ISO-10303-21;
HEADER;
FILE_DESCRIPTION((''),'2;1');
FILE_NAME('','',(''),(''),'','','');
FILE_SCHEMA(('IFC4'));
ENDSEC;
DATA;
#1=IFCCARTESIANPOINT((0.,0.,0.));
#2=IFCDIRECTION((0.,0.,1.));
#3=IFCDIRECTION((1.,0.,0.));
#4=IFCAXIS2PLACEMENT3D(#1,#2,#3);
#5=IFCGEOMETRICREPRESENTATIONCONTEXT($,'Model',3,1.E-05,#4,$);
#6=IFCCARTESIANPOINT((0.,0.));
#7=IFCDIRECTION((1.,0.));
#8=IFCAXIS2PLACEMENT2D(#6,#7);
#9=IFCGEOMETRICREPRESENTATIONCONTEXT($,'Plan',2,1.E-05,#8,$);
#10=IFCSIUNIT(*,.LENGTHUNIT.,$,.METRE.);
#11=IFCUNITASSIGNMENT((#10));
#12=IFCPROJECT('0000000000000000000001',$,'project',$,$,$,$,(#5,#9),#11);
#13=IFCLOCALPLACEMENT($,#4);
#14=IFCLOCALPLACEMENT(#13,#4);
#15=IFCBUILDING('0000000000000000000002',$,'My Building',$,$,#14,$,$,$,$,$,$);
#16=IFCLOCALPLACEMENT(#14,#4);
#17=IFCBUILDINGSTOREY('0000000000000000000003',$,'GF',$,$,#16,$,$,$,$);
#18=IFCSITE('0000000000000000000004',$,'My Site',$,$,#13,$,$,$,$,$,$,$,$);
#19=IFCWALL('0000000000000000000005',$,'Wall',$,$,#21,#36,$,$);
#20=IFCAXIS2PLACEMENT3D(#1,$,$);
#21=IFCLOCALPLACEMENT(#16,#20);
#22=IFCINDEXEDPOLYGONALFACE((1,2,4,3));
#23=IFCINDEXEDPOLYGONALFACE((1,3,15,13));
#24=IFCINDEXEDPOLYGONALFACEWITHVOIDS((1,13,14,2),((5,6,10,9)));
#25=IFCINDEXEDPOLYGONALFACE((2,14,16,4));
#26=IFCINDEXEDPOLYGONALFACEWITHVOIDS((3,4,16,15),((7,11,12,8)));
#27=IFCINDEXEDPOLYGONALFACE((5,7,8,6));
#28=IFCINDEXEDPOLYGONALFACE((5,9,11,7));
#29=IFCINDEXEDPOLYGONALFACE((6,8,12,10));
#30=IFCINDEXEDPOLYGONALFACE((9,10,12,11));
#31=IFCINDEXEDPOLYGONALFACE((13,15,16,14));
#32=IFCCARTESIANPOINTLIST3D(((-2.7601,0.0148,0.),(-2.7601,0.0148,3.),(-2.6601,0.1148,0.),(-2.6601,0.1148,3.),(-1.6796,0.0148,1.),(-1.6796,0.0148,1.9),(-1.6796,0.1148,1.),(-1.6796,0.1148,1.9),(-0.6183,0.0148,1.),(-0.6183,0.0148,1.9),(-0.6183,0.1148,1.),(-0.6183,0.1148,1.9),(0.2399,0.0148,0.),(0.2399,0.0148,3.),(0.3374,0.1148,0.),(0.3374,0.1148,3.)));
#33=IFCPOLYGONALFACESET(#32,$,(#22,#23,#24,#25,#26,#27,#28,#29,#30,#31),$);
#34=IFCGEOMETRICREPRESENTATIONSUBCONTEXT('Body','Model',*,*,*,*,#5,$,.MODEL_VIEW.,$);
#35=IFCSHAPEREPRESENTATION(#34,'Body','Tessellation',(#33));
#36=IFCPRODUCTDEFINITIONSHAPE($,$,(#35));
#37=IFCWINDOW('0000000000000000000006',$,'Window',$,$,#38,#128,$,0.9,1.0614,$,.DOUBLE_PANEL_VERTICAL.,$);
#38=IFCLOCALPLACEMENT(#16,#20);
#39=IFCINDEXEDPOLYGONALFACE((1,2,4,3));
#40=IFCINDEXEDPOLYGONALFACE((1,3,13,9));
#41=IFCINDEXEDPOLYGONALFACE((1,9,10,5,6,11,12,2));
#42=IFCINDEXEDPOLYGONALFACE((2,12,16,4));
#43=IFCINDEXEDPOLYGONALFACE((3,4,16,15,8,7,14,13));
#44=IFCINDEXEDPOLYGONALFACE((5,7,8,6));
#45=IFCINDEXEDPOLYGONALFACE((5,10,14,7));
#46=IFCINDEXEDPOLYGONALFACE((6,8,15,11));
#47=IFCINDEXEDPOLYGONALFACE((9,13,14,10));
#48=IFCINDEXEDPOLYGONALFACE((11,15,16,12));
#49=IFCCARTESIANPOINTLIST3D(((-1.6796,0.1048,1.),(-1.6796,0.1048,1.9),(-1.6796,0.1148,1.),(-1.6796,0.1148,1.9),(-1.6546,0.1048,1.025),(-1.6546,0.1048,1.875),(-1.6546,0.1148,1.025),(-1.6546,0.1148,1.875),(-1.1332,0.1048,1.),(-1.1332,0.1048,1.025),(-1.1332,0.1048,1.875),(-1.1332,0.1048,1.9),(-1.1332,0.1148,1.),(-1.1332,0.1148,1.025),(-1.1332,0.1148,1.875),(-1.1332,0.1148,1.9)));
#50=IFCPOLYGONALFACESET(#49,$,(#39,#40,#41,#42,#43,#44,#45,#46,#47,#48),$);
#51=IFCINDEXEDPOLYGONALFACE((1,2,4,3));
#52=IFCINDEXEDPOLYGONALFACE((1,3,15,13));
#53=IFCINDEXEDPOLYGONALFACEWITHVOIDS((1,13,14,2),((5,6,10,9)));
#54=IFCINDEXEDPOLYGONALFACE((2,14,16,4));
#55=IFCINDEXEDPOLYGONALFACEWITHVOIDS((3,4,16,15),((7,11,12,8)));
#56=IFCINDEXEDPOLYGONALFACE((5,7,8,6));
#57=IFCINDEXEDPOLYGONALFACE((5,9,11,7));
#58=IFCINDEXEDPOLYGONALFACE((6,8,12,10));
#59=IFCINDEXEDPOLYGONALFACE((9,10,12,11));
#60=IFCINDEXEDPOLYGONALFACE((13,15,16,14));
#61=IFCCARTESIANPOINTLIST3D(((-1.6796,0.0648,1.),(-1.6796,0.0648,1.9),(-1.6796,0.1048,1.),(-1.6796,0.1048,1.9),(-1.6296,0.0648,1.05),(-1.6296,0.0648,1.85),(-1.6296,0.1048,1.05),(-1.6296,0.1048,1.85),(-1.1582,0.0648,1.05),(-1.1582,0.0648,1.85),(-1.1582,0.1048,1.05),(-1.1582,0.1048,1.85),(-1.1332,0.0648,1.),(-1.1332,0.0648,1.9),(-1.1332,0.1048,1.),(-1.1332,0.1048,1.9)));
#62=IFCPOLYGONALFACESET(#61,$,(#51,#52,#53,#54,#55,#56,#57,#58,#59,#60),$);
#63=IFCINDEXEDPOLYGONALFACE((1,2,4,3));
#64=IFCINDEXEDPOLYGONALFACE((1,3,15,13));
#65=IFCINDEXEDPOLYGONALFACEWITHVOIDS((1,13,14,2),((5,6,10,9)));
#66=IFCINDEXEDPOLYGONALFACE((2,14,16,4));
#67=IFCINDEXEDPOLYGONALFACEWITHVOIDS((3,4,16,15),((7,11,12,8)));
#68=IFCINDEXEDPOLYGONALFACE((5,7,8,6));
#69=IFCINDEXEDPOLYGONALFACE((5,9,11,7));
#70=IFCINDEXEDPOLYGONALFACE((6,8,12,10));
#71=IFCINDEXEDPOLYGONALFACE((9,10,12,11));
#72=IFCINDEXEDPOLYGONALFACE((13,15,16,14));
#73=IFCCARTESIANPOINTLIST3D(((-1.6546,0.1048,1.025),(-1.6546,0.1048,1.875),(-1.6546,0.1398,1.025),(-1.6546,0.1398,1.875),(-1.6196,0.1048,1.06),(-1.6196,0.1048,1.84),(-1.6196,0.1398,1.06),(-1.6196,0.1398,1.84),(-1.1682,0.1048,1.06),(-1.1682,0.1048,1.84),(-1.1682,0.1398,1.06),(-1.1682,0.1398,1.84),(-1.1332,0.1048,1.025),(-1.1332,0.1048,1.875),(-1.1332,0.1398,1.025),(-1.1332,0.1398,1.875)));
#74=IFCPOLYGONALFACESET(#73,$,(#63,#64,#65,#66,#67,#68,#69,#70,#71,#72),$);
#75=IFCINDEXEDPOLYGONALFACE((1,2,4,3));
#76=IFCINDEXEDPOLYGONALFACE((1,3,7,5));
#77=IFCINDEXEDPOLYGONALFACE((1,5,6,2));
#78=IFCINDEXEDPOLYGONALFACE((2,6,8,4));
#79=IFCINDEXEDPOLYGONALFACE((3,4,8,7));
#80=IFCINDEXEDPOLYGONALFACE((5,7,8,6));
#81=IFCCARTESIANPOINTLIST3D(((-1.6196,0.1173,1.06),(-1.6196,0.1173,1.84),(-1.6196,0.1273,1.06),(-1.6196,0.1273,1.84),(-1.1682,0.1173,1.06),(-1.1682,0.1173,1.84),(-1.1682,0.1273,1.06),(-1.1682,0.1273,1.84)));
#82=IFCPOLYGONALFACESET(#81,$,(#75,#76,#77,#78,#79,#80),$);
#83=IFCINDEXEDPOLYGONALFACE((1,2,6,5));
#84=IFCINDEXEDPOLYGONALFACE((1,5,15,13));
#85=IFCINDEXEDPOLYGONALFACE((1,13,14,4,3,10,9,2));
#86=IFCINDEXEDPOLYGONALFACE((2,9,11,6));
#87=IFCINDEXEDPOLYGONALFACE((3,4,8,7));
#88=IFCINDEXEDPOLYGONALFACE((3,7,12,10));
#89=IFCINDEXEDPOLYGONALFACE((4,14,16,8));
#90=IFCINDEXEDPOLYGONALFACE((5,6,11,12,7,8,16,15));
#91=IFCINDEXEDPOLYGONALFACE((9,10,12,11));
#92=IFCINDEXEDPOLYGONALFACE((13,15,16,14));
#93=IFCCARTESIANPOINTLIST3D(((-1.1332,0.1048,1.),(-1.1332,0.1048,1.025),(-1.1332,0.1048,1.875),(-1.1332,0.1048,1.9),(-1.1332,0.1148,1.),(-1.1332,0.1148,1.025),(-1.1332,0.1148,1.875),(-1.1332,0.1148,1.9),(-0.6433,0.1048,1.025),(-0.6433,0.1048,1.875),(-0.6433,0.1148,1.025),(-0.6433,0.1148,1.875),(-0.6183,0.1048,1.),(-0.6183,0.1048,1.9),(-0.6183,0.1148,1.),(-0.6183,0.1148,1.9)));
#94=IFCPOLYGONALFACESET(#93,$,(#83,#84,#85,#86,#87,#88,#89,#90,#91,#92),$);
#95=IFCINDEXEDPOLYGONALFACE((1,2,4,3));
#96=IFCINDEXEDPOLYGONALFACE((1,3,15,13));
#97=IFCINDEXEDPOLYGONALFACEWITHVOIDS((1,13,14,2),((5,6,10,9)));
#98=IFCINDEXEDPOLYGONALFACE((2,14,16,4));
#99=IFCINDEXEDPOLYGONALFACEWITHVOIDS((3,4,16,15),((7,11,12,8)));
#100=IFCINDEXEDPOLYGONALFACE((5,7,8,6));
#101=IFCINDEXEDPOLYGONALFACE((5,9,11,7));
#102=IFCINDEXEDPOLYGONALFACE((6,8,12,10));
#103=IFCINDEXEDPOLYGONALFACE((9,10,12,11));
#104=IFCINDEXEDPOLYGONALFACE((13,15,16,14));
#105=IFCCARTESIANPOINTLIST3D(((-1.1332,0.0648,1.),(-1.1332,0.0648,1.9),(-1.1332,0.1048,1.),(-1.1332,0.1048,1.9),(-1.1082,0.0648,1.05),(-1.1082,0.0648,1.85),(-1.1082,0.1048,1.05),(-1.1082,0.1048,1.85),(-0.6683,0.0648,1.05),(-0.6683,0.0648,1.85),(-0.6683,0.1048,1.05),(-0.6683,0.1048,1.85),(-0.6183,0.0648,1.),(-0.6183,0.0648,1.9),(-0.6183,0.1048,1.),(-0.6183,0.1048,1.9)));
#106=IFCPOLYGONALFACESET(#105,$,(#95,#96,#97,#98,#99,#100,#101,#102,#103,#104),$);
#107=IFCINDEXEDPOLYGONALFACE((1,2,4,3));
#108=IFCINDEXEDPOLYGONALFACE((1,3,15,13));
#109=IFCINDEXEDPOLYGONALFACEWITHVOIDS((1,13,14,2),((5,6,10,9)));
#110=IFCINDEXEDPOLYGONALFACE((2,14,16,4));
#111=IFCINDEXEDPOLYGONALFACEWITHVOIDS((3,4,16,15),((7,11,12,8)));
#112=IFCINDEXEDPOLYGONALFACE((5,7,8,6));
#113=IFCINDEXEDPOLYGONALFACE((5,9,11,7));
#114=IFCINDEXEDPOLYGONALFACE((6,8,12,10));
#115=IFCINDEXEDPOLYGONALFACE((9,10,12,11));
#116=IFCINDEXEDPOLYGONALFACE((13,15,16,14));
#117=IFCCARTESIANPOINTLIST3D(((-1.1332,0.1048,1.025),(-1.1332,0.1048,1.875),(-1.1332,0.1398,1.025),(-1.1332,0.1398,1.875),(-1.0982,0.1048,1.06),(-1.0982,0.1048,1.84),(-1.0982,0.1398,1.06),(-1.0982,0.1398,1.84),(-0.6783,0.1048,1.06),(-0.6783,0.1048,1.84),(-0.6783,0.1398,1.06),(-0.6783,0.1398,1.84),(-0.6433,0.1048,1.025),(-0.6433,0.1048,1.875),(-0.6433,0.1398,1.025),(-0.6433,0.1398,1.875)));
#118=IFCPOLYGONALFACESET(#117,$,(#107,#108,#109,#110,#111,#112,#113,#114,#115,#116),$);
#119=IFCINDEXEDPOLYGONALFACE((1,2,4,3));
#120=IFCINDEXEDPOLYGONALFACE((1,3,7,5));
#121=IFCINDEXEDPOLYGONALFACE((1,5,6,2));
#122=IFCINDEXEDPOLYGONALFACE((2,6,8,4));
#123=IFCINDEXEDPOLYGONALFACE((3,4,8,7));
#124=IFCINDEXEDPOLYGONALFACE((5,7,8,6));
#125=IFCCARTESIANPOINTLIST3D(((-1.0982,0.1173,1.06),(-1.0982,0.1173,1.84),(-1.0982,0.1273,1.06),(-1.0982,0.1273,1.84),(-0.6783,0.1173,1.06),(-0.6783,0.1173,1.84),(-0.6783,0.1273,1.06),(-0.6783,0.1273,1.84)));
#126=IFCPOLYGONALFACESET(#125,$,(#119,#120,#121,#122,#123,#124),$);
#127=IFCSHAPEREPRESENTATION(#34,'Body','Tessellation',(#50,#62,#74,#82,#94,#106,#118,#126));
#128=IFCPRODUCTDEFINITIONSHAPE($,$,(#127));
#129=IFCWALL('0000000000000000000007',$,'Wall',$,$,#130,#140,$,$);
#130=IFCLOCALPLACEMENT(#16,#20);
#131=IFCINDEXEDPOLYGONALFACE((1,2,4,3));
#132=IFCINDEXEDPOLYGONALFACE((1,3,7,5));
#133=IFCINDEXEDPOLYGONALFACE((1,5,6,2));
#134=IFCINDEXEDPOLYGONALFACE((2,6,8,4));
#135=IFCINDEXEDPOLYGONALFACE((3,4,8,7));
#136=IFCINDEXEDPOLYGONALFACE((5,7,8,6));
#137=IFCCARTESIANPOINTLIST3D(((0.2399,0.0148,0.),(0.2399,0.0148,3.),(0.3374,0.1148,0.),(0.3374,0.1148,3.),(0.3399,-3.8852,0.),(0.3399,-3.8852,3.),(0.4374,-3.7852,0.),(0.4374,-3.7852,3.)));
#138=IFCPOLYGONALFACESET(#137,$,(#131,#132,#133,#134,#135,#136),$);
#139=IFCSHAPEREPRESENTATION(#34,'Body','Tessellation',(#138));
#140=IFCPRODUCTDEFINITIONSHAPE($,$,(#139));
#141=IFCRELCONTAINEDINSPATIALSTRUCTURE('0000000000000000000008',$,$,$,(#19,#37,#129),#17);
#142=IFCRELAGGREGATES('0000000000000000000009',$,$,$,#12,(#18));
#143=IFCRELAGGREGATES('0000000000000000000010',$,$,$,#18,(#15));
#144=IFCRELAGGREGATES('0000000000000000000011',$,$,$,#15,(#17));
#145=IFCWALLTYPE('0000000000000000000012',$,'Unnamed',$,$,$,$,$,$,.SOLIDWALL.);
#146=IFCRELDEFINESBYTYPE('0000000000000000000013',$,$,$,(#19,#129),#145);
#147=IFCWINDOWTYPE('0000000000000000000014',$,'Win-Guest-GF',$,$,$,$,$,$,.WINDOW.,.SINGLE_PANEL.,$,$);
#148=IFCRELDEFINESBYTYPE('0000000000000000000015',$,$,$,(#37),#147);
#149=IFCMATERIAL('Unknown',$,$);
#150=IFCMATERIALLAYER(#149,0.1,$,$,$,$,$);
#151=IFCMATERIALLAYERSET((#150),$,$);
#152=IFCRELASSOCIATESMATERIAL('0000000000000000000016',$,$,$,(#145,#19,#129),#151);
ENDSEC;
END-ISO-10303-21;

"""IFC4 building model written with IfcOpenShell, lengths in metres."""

from ifc_helpers import new_model, entity, si_unit, frame, origin_with_axes, origin_2d_with_axis, place, context, subcontext, project, spatial, line, indexed_curve, outline, extrude, shape, source, transform, mapped, material, layer, layer_set, layer_usage, type_object, type_shapes, element, fill, save


model = new_model("IFC4")

# Units and contexts
model_context = context("Model", 3, precision=1e-05, world=origin_with_axes())
plan_context = context("Plan", 2, precision=1e-05, world=origin_2d_with_axis())
body_context_1 = subcontext(model_context, "Body", "Model", "MODEL_VIEW")
body_context_2 = subcontext(plan_context, "Body", "Plan", "PLAN_VIEW")
ifc_project = project(units=[si_unit("LENGTHUNIT", "METRE")], contexts=[model_context, plan_context])

# Site, building, storey
site_placement = place(None, origin_with_axes())
site = spatial("IfcSite", under=ifc_project, at=site_placement, Name="My Site")
building_placement = place(site_placement, origin_with_axes())
building = spatial("IfcBuilding", under=site, at=building_placement, Name="My Building")
storey_placement = place(building_placement, origin_with_axes())
storey = spatial("IfcBuildingStorey", under=building, at=storey_placement, Name="GF")

# Shared definitions
ifc_material = material(Name="Unknown")

# Shared definitions
ifc_layer_1 = layer(ifc_material, 0.1)
ifc_layer_set_1 = layer_set([ifc_layer_1])
wall_type = type_object("IfcWallType", Name="Unnamed", PredefinedType="SOLIDWALL", material=ifc_layer_set_1)

# Wall, opening, window
ifc_layer_usage_1 = layer_usage(ifc_layer_set_1, "AXIS2", "POSITIVE", 0.0)
wall_1_placement = place(storey_placement, frame((-2.7601, 0.0148, 0.0), z_axis=(0.0, 0.0, 1.0), x_axis=(1.0, 0.0, 0.0)))
wall_1 = element("IfcWall", 1, at=wall_1_placement, inside=storey, type_object=wall_type, material=ifc_layer_usage_1, Name="Wall", context=body_context_1, shape_type="SweptSolid", body=[
    extrude(outline(indexed_curve([(0.0, 0.0), (0.1, 0.1), (3.0975, 0.1), (3.0, 0.0)], segments=[line(1, 2, 3, 4, 1)])), origin_with_axes(), (0.0, 0.0, 1.0), 3.0),
])
shared_shape_1 = source(origin_with_axes(), body_context_1, "Body", "SweptSolid", [
    extrude(outline(indexed_curve([(0.0, 0.0), (1.0614, 0.0), (1.0614, 0.9), (0.0, 0.9)], segments=[line(1, 2, 3, 4, 1)])), frame((0.0, -0.6, 0.0), z_axis=(0.0, -1.0, 0.0), x_axis=(1.0, 0.0, 0.0)), (0.0, 0.0, -1.0), 1.2),
])
opening_1_placement = place(wall_1_placement, frame((1.0805, 0.0, 1.0), z_axis=(0.0, 0.0, 1.0), x_axis=(1.0, 0.0, 0.0)))
opening_1 = element("IfcOpeningElement", 2, at=opening_1_placement, cuts=wall_1, PredefinedType="OPENING", context=body_context_1, shape_type="MappedRepresentation", body=[
    mapped(shared_shape_1, transform((0.0, 0.0, 0.0), x_axis=(1.0, 0.0, 0.0), y_axis=(0.0, 1.0, 0.0), z_axis=(0.0, 0.0, 1.0), scale=1.0)),
])
window_type_1 = type_object("IfcWindowType", Name="Win-Guest-GF", PartitioningType="SINGLE_PANEL", PredefinedType="WINDOW")
shared_shape_2 = source(origin_with_axes(), body_context_1, "Body", "SweptSolid", [
    extrude(outline(indexed_curve([(0.5465, 0.0), (0.0, 0.0), (0.0, 0.9), (0.5465, 0.9), (0.5465, 0.875), (0.025, 0.875), (0.025, 0.025), (0.5465, 0.025)], segments=[line(1, 2, 3, 4, 5, 6, 7, 8, 1)])), frame((0.0, 0.09, 0.0), z_axis=(0.0, -1.0, 0.0), x_axis=(1.0, 0.0, 0.0)), (0.0, 0.0, -1.0), 0.01),
    extrude(outline(indexed_curve([(0.0, 0.0), (0.5465, 0.0), (0.5465, 0.9), (0.0, 0.9)], segments=[line(1, 2, 3, 4, 1)]), holes=[indexed_curve([(0.05, 0.05), (0.5215, 0.05), (0.5215, 0.85), (0.05, 0.85)], segments=[line(1, 2, 3, 4, 1)])]), frame((0.0, 0.05, 0.0), z_axis=(0.0, -1.0, 0.0), x_axis=(1.0, 0.0, 0.0)), (0.0, 0.0, -1.0), 0.04),
    extrude(outline(indexed_curve([(0.0, 0.0), (0.5215, 0.0), (0.5215, 0.85), (0.0, 0.85)], segments=[line(1, 2, 3, 4, 1)]), holes=[indexed_curve([(0.035, 0.035), (0.4865, 0.035), (0.4865, 0.815), (0.035, 0.815)], segments=[line(1, 2, 3, 4, 1)])]), frame((0.025, 0.09, 0.025), z_axis=(0.0, -1.0, 0.0), x_axis=(1.0, 0.0, 0.0)), (0.0, 0.0, -1.0), 0.035),
    extrude(outline(indexed_curve([(0.035, 0.035), (0.4865, 0.035), (0.4865, 0.815), (0.035, 0.815)], segments=[line(1, 2, 3, 4, 1)])), frame((0.025, 0.1025, 0.025), z_axis=(0.0, -1.0, 0.0), x_axis=(1.0, 0.0, 0.0)), (0.0, 0.0, -1.0), 0.01),
    extrude(outline(indexed_curve([(0.0, 0.9), (0.5149, 0.9), (0.5149, 0.0), (0.0, 0.0), (0.0, 0.025), (0.4899, 0.025), (0.4899, 0.875), (0.0, 0.875)], segments=[line(1, 2, 3, 4, 5, 6, 7, 8, 1)])), frame((0.5465, 0.09, 0.0), z_axis=(0.0, -1.0, 0.0), x_axis=(1.0, 0.0, 0.0)), (0.0, 0.0, -1.0), 0.01),
    extrude(outline(indexed_curve([(0.0, 0.0), (0.5149, 0.0), (0.5149, 0.9), (0.0, 0.9)], segments=[line(1, 2, 3, 4, 1)]), holes=[indexed_curve([(0.025, 0.05), (0.4649, 0.05), (0.4649, 0.85), (0.025, 0.85)], segments=[line(1, 2, 3, 4, 1)])]), frame((0.5465, 0.05, 0.0), z_axis=(0.0, -1.0, 0.0), x_axis=(1.0, 0.0, 0.0)), (0.0, 0.0, -1.0), 0.04),
    extrude(outline(indexed_curve([(0.0, 0.0), (0.4899, 0.0), (0.4899, 0.85), (0.0, 0.85)], segments=[line(1, 2, 3, 4, 1)]), holes=[indexed_curve([(0.035, 0.035), (0.4549, 0.035), (0.4549, 0.815), (0.035, 0.815)], segments=[line(1, 2, 3, 4, 1)])]), frame((0.5465, 0.09, 0.025), z_axis=(0.0, -1.0, 0.0), x_axis=(1.0, 0.0, 0.0)), (0.0, 0.0, -1.0), 0.035),
    extrude(outline(indexed_curve([(0.035, 0.035), (0.4549, 0.035), (0.4549, 0.815), (0.035, 0.815)], segments=[line(1, 2, 3, 4, 1)])), frame((0.5465, 0.1025, 0.025), z_axis=(0.0, -1.0, 0.0), x_axis=(1.0, 0.0, 0.0)), (0.0, 0.0, -1.0), 0.01),
])
shared_shape_3 = source(origin_with_axes(), body_context_2, "Body", "Curve2D", [
    entity("IfcIndexedPolyCurve", entity("IfcCartesianPointList2D", [[0.05, 0.05], [0.5215, 0.05]])),
    entity("IfcIndexedPolyCurve", entity("IfcCartesianPointList2D", [[0.0, 0.1], [0.025, 0.1], [0.025, 0.09], [0.05, 0.09], [0.05, 0.05], [0.0, 0.05]]), [entity("IfcLineIndex", [1, 2, 3, 4, 5, 6, 1])]),
    entity("IfcIndexedPolyCurve", entity("IfcCartesianPointList2D", [[0.5465, 0.1], [0.5465, 0.1], [0.5465, 0.09], [0.5215, 0.09], [0.5215, 0.05], [0.5465, 0.05]])),
    entity("IfcIndexedPolyCurve", entity("IfcCartesianPointList2D", [[0.025, 0.09], [0.06, 0.09], [0.06, 0.125], [0.025, 0.125]]), [entity("IfcLineIndex", [1, 2, 3, 4, 1])]),
    entity("IfcIndexedPolyCurve", entity("IfcCartesianPointList2D", [[0.5465, 0.09], [0.5115, 0.09], [0.5115, 0.125], [0.5465, 0.125]]), [entity("IfcLineIndex", [1, 2, 3, 4, 1])]),
    entity("IfcIndexedPolyCurve", entity("IfcCartesianPointList2D", [[0.06, 0.09], [0.5115, 0.09]])),
    entity("IfcIndexedPolyCurve", entity("IfcCartesianPointList2D", [[0.06, 0.125], [0.5115, 0.125]])),
    entity("IfcIndexedPolyCurve", entity("IfcCartesianPointList2D", [[0.06, 0.1075], [0.5115, 0.1075]])),
    entity("IfcIndexedPolyCurve", entity("IfcCartesianPointList2D", [[0.5715, 0.05], [1.0114, 0.05]])),
    entity("IfcIndexedPolyCurve", entity("IfcCartesianPointList2D", [[0.5465, 0.1], [0.5465, 0.1], [0.5465, 0.09], [0.5715, 0.09], [0.5715, 0.05], [0.5465, 0.05]])),
    entity("IfcIndexedPolyCurve", entity("IfcCartesianPointList2D", [[1.0614, 0.1], [1.0364, 0.1], [1.0364, 0.09], [1.0114, 0.09], [1.0114, 0.05], [1.0614, 0.05]]), [entity("IfcLineIndex", [1, 2, 3, 4, 5, 6, 1])]),
    entity("IfcIndexedPolyCurve", entity("IfcCartesianPointList2D", [[0.5465, 0.09], [0.5815, 0.09], [0.5815, 0.125], [0.5465, 0.125]]), [entity("IfcLineIndex", [1, 2, 3, 4, 1])]),
    entity("IfcIndexedPolyCurve", entity("IfcCartesianPointList2D", [[1.0364, 0.09], [1.0014, 0.09], [1.0014, 0.125], [1.0364, 0.125]]), [entity("IfcLineIndex", [1, 2, 3, 4, 1])]),
    entity("IfcIndexedPolyCurve", entity("IfcCartesianPointList2D", [[0.5815, 0.09], [1.0014, 0.09]])),
    entity("IfcIndexedPolyCurve", entity("IfcCartesianPointList2D", [[0.5815, 0.125], [1.0014, 0.125]])),
    entity("IfcIndexedPolyCurve", entity("IfcCartesianPointList2D", [[0.5815, 0.1075], [1.0014, 0.1075]])),
])
type_shapes(window_type_1, [shared_shape_2, shared_shape_3])
window_1_placement = place(opening_1_placement, origin_with_axes())
window_1 = element("IfcWindow", 3, at=window_1_placement, inside=storey, type_object=window_type_1, Name="Window", OverallHeight=0.9, OverallWidth=1.0614, PartitioningType="DOUBLE_PANEL_VERTICAL", shapes=[
    shape(body_context_1, "Body", "MappedRepresentation", [mapped(shared_shape_2, transform((0.0, 0.0, 0.0), x_axis=(1.0, 0.0, 0.0), y_axis=(0.0, 1.0, 0.0), z_axis=(0.0, 0.0, 1.0), scale=1.0))]),
    shape(body_context_2, "Body", "MappedRepresentation", [mapped(shared_shape_3, transform((0.0, 0.0, 0.0), x_axis=(1.0, 0.0, 0.0), y_axis=(0.0, 1.0, 0.0), z_axis=(0.0, 0.0, 1.0), scale=1.0))]),
])
fill(opening_1, window_1)

# Wall
ifc_layer_usage_2 = layer_usage(ifc_layer_set_1, "AXIS2", "POSITIVE", 0.0)
wall_2_placement = place(storey_placement, frame((0.2399, 0.0148, 0.0), z_axis=(0.0, 0.0, 1.0), x_axis=(0.025633, -0.999671, 0.0)))
element("IfcWall", 4, at=wall_2_placement, inside=storey, type_object=wall_type, material=ifc_layer_usage_2, Name="Wall", context=body_context_1, shape_type="SweptSolid", body=[
    extrude(outline(indexed_curve([(0.0, 0.0), (-0.0975, 0.1), (3.8038, 0.1), (3.9013, 0.0)], segments=[line(1, 2, 3, 4, 1)])), origin_with_axes(), (0.0, 0.0, 1.0), 3.0),
])

save(model, "model.ifc")
